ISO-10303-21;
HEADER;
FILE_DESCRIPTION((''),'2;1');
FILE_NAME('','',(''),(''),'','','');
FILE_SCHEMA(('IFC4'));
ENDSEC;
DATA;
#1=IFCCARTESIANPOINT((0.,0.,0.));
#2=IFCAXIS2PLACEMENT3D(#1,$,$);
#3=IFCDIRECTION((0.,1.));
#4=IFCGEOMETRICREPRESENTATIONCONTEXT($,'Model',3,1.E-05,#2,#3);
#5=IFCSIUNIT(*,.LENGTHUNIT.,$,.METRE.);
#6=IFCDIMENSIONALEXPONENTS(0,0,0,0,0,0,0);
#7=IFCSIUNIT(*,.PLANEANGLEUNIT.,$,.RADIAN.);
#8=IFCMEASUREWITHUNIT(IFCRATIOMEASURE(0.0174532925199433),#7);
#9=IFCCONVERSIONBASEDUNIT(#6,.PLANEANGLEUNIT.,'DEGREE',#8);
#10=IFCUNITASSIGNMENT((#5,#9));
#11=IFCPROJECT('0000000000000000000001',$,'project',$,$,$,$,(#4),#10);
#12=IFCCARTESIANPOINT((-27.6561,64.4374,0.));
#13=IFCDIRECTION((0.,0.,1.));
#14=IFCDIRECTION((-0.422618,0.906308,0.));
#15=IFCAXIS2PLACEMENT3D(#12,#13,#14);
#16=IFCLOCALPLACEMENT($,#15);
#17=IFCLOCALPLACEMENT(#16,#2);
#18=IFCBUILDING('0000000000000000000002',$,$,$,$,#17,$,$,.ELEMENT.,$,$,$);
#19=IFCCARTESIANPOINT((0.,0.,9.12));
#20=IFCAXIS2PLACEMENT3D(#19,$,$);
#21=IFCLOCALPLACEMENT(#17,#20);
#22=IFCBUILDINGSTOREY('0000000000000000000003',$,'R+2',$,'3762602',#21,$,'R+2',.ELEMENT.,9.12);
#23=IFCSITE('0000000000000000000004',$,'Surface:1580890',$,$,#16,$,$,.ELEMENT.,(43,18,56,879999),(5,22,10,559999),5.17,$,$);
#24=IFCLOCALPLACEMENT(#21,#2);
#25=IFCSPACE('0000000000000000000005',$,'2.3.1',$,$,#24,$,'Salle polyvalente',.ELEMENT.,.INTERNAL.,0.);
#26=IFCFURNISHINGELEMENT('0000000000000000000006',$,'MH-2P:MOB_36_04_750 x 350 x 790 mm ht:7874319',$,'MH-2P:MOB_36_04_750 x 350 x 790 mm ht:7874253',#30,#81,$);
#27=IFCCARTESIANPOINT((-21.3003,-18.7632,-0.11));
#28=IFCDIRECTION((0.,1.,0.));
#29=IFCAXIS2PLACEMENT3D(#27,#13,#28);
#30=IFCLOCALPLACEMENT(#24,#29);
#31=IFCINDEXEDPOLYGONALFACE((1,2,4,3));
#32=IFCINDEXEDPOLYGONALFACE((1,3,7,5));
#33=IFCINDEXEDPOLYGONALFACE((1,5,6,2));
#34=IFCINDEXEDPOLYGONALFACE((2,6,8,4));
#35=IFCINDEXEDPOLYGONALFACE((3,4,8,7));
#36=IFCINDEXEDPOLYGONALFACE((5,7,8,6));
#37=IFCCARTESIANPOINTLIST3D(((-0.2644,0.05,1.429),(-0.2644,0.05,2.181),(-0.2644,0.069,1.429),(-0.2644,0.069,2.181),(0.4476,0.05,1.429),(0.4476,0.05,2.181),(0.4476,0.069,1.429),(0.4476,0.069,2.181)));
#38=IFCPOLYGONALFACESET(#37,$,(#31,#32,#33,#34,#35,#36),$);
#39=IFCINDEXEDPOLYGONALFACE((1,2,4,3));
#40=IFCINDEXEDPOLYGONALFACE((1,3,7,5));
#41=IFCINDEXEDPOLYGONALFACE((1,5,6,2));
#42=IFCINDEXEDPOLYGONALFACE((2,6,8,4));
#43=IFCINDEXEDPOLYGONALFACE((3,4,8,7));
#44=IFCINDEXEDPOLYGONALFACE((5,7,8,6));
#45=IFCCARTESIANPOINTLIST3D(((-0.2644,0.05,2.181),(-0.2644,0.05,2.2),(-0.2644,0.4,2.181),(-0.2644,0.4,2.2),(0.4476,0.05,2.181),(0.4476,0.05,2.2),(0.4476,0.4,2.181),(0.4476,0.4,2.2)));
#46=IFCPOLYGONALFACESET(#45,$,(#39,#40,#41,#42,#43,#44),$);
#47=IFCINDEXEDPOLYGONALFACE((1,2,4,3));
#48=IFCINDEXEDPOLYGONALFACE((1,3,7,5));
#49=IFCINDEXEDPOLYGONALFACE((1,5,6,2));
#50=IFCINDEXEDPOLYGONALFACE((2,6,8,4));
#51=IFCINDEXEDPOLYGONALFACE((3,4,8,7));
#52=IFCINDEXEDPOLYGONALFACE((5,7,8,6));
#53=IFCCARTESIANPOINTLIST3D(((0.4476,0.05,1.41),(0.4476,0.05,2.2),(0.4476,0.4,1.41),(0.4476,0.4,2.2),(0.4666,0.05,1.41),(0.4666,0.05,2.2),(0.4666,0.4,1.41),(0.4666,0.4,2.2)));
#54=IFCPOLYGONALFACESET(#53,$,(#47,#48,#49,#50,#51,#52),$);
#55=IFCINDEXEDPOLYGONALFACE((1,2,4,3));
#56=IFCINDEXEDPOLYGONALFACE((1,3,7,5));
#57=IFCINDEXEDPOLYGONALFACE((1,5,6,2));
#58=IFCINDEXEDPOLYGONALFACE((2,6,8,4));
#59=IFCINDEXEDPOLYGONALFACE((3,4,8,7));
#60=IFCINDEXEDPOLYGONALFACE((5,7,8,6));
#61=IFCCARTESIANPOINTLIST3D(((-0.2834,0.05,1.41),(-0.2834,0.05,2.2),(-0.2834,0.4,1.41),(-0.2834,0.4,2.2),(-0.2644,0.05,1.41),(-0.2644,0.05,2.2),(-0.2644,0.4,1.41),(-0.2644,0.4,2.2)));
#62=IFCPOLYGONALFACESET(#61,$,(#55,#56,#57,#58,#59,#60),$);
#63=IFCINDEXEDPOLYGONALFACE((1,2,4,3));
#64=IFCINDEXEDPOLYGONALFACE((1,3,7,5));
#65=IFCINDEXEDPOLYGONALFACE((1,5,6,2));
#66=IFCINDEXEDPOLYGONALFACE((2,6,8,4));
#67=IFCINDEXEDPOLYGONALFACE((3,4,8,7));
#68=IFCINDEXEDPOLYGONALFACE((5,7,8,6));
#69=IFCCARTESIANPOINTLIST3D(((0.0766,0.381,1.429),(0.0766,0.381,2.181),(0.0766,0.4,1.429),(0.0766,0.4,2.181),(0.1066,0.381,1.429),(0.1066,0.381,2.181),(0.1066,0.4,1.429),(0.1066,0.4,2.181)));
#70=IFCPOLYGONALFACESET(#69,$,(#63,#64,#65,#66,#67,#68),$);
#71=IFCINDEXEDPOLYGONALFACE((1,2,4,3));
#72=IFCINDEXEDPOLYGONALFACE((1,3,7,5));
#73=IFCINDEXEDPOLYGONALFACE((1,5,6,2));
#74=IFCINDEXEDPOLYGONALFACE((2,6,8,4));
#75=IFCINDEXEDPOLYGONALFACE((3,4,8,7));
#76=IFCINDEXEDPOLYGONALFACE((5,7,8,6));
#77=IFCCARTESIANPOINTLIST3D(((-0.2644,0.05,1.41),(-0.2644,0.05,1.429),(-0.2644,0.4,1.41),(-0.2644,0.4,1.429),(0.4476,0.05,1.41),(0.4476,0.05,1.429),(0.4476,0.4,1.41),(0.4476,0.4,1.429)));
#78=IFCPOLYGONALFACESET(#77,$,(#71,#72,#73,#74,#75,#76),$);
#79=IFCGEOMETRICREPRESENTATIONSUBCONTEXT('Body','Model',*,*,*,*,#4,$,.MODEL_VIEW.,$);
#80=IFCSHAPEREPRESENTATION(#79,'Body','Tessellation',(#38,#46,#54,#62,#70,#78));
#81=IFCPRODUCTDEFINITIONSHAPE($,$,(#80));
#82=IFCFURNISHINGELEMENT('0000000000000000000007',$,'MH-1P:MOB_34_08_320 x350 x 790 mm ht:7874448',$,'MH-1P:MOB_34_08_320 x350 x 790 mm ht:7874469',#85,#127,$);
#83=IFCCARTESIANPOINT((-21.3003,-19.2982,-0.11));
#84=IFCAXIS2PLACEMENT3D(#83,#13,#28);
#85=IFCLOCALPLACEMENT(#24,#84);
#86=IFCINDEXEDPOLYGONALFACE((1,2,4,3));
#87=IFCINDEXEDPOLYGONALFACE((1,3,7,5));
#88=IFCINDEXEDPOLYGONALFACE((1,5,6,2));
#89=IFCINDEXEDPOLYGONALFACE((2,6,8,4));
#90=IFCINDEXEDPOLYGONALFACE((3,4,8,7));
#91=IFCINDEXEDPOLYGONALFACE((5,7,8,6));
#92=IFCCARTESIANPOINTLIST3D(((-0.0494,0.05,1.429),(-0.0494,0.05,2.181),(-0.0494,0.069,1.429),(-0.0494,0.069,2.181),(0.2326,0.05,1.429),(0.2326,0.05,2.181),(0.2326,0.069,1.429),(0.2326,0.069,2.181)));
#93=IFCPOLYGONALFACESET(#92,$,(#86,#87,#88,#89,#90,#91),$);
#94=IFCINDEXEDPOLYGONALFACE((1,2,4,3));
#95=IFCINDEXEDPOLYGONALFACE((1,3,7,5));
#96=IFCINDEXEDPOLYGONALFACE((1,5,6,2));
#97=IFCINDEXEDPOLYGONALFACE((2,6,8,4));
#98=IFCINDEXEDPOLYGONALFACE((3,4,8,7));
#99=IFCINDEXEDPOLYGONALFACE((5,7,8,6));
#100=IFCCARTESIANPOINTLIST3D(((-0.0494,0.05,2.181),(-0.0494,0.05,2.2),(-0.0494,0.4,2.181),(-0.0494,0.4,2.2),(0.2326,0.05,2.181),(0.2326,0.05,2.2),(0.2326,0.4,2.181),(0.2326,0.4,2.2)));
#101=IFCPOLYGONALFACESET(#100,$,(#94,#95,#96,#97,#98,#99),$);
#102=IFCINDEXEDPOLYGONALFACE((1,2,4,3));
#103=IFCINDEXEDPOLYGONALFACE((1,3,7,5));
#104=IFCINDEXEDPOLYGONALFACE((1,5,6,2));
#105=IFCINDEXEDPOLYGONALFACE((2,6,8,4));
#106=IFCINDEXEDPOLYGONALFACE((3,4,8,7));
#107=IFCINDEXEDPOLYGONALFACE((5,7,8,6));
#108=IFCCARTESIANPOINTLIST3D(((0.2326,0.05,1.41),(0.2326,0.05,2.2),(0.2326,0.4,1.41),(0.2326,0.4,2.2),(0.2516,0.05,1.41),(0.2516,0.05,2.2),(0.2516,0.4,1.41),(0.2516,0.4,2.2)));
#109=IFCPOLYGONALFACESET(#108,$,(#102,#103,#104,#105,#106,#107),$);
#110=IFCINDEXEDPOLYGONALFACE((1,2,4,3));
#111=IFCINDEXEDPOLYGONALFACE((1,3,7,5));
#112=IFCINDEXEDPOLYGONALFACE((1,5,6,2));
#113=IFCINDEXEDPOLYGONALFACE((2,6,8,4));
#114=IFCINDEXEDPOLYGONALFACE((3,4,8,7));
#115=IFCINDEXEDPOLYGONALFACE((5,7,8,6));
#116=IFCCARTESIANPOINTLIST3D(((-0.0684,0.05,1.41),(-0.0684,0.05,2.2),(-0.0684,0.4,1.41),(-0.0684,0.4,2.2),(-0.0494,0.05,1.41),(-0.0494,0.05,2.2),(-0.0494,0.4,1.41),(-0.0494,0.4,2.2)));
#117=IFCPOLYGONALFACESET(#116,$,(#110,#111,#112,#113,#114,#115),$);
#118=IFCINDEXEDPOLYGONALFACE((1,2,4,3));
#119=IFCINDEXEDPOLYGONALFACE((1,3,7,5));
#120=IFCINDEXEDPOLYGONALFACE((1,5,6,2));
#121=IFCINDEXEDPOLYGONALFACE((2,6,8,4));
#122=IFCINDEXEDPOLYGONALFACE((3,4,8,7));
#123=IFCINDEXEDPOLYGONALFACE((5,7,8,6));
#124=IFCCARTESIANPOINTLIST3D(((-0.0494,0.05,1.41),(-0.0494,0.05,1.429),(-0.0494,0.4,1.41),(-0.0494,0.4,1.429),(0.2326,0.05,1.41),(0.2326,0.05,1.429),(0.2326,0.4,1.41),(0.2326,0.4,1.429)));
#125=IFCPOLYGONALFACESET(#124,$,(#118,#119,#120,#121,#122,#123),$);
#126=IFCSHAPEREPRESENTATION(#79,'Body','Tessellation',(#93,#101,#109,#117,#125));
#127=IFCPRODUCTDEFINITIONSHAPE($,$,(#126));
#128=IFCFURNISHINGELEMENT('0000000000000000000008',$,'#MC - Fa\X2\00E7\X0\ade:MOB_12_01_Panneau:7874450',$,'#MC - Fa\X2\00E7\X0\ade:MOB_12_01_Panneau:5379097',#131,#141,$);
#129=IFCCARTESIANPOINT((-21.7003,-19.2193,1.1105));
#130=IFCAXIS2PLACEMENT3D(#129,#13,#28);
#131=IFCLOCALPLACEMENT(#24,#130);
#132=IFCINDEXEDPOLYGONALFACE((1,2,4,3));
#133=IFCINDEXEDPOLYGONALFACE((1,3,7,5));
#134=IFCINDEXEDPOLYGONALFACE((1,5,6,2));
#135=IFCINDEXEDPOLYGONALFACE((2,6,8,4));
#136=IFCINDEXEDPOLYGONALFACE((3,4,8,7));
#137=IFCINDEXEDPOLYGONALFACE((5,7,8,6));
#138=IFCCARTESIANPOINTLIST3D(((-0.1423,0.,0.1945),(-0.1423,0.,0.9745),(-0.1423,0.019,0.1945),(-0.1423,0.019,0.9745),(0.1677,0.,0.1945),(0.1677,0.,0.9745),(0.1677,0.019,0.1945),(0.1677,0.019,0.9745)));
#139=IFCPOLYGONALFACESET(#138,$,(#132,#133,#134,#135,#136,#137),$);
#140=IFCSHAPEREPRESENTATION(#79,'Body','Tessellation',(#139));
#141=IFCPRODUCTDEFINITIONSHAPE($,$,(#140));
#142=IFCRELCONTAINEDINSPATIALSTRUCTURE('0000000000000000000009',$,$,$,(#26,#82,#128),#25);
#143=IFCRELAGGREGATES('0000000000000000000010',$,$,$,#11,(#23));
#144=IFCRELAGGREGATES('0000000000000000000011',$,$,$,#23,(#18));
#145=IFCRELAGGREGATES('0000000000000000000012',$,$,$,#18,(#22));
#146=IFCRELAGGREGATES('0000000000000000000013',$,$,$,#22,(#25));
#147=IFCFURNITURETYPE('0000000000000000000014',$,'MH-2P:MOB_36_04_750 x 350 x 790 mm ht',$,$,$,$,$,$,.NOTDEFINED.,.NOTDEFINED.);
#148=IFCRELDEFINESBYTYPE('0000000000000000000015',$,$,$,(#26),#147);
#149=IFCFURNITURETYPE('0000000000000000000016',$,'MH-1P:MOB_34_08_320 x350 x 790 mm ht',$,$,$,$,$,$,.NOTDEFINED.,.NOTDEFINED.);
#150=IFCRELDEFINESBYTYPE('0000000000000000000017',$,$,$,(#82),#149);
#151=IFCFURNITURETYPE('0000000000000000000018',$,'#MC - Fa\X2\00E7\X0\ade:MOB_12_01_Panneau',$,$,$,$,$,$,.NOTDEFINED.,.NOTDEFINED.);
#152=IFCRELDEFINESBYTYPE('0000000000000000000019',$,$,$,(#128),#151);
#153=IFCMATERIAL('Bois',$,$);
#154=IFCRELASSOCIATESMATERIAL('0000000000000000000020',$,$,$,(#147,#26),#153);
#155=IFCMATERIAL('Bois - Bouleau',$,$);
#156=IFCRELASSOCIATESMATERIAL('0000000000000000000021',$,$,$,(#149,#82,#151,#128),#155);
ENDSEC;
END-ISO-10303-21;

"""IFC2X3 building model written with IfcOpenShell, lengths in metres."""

from ifc_helpers import new_model, entity, si_unit, converted_unit, direction, frame, frame_2d, origin, origin_2d_with_axis, place, context, subcontext, project, spatial, rectangle, extrude, source, transform, mapped, material, type_object, type_shapes, element, save


model = new_model("IFC2X3")

# Units and contexts
model_context = context("Model", 3, precision=1e-05, world=origin(), true_north=direction((0.0, 1.0)))
body_context = subcontext(model_context, "Body", "Model", "MODEL_VIEW")
ifc_project = project(units=[si_unit("LENGTHUNIT", "METRE"), converted_unit("PLANEANGLEUNIT", "DEGREE", entity("IfcRatioMeasure", 0.0174532925199433), si_unit("PLANEANGLEUNIT", "RADIAN"), dimensions=[0, 0, 0, 0, 0, 0, 0])], contexts=[model_context])

# Site, building, storey
site_placement = place(None, frame((-27.6561, 64.4374, 0.0), z_axis=(0.0, 0.0, 1.0), x_axis=(-0.422618, 0.906308, 0.0)))
site = spatial("IfcSite", under=ifc_project, at=site_placement, Name="Surface:1580890", CompositionType="ELEMENT", RefLatitude=(43, 18, 56, 879999), RefLongitude=(5, 22, 10, 559999), RefElevation=5.17)
building_placement = place(site_placement, origin())
building = spatial("IfcBuilding", under=site, at=building_placement, CompositionType="ELEMENT")
storey_placement = place(building_placement, frame((0.0, 0.0, 9.12)))
storey = spatial("IfcBuildingStorey", under=building, at=storey_placement, Name="R+2", ObjectType="3762602", LongName="R+2", CompositionType="ELEMENT", Elevation=9.12)

# Shared definitions
space_placement = place(storey_placement, origin())
space = spatial("IfcSpace", under=storey, at=space_placement, Name="2.3.1", LongName="Salle polyvalente", CompositionType="ELEMENT", InteriorOrExteriorSpace="INTERNAL", ElevationWithFlooring=0.0)

# Furnishing elements
ifc_material_1 = material(Name="Bois")
furniture_type_1 = type_object("IfcFurnitureType", Name="MH-2P:MOB_36_04_750 x 350 x 790 mm ht", material=ifc_material_1)
shared_shape_1 = source(origin(), body_context, "Body", "SweptSolid", [
    extrude(rectangle(XDim=0.019, YDim=0.712, at=origin_2d_with_axis()), frame((0.0916, 0.0595, 1.429), z_axis=(0.0, 0.0, 1.0), x_axis=(0.0, 1.0, 0.0)), (0.0, 0.0, 1.0), 0.752),
    extrude(rectangle(XDim=0.35, YDim=0.712, at=frame_2d((0.0, 0.0), x_axis=(1.0, 0.0))), frame((0.0916, 0.225, 2.181), z_axis=(0.0, 0.0, 1.0), x_axis=(0.0, 1.0, 0.0)), (0.0, 0.0, 1.0), 0.019),
    extrude(rectangle(XDim=0.35, YDim=0.019, at=origin_2d_with_axis()), frame((0.4571, 0.225, 1.41), z_axis=(0.0, 0.0, 1.0), x_axis=(0.0, 1.0, 0.0)), (0.0, 0.0, 1.0), 0.79),
    extrude(rectangle(XDim=0.35, YDim=0.019, at=origin_2d_with_axis()), frame((-0.2739, 0.225, 1.41), z_axis=(0.0, 0.0, 1.0), x_axis=(0.0, 1.0, 0.0)), (0.0, 0.0, 1.0), 0.79),
    extrude(rectangle(XDim=0.019, YDim=0.03, at=frame_2d((0.0, 0.0), x_axis=(1.0, 0.0))), frame((0.0916, 0.3905, 1.429), z_axis=(0.0, 0.0, 1.0), x_axis=(0.0, 1.0, 0.0)), (0.0, 0.0, 1.0), 0.752),
    extrude(rectangle(XDim=0.35, YDim=0.712, at=origin_2d_with_axis()), frame((0.0916, 0.225, 1.41), z_axis=(0.0, 0.0, 1.0), x_axis=(0.0, 1.0, 0.0)), (0.0, 0.0, 1.0), 0.019),
])
type_shapes(furniture_type_1, [shared_shape_1])
for number, where, z_axis, x_axis, name in (
    (1, (-21.3003, -18.7632, -0.11), (0.0, 0.0, 1.0), (0.0, 1.0, 0.0), "MH-2P:MOB_36_04_750 x 350 x 790 mm ht:7874319"),
):
    element("IfcFurnishingElement", number, at=place(space_placement, frame(where, z_axis=z_axis, x_axis=x_axis)), inside=space, type_object=furniture_type_1, material=ifc_material_1, Name=name, ObjectType="MH-2P:MOB_36_04_750 x 350 x 790 mm ht:7874253", context=body_context, shape_type="MappedRepresentation", body=[
        mapped(shared_shape_1, transform((0.0, 0.0, 0.0), scale=1.0)),
    ])
ifc_material_2 = material(Name="Bois - Bouleau")
furniture_type_2 = type_object("IfcFurnitureType", Name="MH-1P:MOB_34_08_320 x350 x 790 mm ht", material=ifc_material_2)
shared_shape_2 = source(origin(), body_context, "Body", "SweptSolid", [
    extrude(rectangle(XDim=0.282, YDim=0.019, at=frame_2d((0.0, 0.0), x_axis=(1.0, 0.0))), frame((0.0916, 0.0595, 1.429)), (0.0, 0.0, 1.0), 0.752),
    extrude(rectangle(XDim=0.35, YDim=0.282, at=frame_2d((0.0, 0.0), x_axis=(1.0, 0.0))), frame((0.0916, 0.225, 2.181), z_axis=(0.0, 0.0, 1.0), x_axis=(0.0, 1.0, 0.0)), (0.0, 0.0, 1.0), 0.019),
    extrude(rectangle(XDim=0.35, YDim=0.019, at=origin_2d_with_axis()), frame((0.2421, 0.225, 1.41), z_axis=(0.0, 0.0, 1.0), x_axis=(0.0, 1.0, 0.0)), (0.0, 0.0, 1.0), 0.79),
    extrude(rectangle(XDim=0.35, YDim=0.019, at=frame_2d((0.0, 0.0), x_axis=(1.0, 0.0))), frame((-0.0589, 0.225, 1.41), z_axis=(0.0, 0.0, 1.0), x_axis=(0.0, 1.0, 0.0)), (0.0, 0.0, 1.0), 0.79),
    extrude(rectangle(XDim=0.35, YDim=0.282, at=origin_2d_with_axis()), frame((0.0916, 0.225, 1.41), z_axis=(0.0, 0.0, 1.0), x_axis=(0.0, 1.0, 0.0)), (0.0, 0.0, 1.0), 0.019),
])
type_shapes(furniture_type_2, [shared_shape_2])
furnishing_1_placement = place(space_placement, frame((-21.3003, -19.2982, -0.11), z_axis=(0.0, 0.0, 1.0), x_axis=(0.0, 1.0, 0.0)))
element("IfcFurnishingElement", 2, at=furnishing_1_placement, inside=space, type_object=furniture_type_2, material=ifc_material_2, Name="MH-1P:MOB_34_08_320 x350 x 790 mm ht:7874448", ObjectType="MH-1P:MOB_34_08_320 x350 x 790 mm ht:7874469", context=body_context, shape_type="MappedRepresentation", body=[
    mapped(shared_shape_2, transform((0.0, 0.0, 0.0), scale=1.0)),
])
furniture_type_3 = type_object("IfcFurnitureType", Name="#MC - Façade:MOB_12_01_Panneau", material=ifc_material_2)
shared_shape_3 = source(origin(), body_context, "Body", "SweptSolid", [
    extrude(rectangle(XDim=0.019, YDim=0.31, at=origin_2d_with_axis()), frame((0.0127, 0.0095, 0.1945), z_axis=(0.0, 0.0, 1.0), x_axis=(0.0, 1.0, 0.0)), (0.0, 0.0, 1.0), 0.78),
])
type_shapes(furniture_type_3, [shared_shape_3])
furnishing_2_placement = place(space_placement, frame((-21.7003, -19.2193, 1.1105), z_axis=(0.0, 0.0, 1.0), x_axis=(0.0, 1.0, 0.0)))
element("IfcFurnishingElement", 3, at=furnishing_2_placement, inside=space, type_object=furniture_type_3, material=ifc_material_2, Name="#MC - Façade:MOB_12_01_Panneau:7874450", ObjectType="#MC - Façade:MOB_12_01_Panneau:5379097", context=body_context, shape_type="MappedRepresentation", body=[
    mapped(shared_shape_3, transform((0.0, 0.0, 0.0), scale=1.0)),
])

save(model, "model.ifc")
